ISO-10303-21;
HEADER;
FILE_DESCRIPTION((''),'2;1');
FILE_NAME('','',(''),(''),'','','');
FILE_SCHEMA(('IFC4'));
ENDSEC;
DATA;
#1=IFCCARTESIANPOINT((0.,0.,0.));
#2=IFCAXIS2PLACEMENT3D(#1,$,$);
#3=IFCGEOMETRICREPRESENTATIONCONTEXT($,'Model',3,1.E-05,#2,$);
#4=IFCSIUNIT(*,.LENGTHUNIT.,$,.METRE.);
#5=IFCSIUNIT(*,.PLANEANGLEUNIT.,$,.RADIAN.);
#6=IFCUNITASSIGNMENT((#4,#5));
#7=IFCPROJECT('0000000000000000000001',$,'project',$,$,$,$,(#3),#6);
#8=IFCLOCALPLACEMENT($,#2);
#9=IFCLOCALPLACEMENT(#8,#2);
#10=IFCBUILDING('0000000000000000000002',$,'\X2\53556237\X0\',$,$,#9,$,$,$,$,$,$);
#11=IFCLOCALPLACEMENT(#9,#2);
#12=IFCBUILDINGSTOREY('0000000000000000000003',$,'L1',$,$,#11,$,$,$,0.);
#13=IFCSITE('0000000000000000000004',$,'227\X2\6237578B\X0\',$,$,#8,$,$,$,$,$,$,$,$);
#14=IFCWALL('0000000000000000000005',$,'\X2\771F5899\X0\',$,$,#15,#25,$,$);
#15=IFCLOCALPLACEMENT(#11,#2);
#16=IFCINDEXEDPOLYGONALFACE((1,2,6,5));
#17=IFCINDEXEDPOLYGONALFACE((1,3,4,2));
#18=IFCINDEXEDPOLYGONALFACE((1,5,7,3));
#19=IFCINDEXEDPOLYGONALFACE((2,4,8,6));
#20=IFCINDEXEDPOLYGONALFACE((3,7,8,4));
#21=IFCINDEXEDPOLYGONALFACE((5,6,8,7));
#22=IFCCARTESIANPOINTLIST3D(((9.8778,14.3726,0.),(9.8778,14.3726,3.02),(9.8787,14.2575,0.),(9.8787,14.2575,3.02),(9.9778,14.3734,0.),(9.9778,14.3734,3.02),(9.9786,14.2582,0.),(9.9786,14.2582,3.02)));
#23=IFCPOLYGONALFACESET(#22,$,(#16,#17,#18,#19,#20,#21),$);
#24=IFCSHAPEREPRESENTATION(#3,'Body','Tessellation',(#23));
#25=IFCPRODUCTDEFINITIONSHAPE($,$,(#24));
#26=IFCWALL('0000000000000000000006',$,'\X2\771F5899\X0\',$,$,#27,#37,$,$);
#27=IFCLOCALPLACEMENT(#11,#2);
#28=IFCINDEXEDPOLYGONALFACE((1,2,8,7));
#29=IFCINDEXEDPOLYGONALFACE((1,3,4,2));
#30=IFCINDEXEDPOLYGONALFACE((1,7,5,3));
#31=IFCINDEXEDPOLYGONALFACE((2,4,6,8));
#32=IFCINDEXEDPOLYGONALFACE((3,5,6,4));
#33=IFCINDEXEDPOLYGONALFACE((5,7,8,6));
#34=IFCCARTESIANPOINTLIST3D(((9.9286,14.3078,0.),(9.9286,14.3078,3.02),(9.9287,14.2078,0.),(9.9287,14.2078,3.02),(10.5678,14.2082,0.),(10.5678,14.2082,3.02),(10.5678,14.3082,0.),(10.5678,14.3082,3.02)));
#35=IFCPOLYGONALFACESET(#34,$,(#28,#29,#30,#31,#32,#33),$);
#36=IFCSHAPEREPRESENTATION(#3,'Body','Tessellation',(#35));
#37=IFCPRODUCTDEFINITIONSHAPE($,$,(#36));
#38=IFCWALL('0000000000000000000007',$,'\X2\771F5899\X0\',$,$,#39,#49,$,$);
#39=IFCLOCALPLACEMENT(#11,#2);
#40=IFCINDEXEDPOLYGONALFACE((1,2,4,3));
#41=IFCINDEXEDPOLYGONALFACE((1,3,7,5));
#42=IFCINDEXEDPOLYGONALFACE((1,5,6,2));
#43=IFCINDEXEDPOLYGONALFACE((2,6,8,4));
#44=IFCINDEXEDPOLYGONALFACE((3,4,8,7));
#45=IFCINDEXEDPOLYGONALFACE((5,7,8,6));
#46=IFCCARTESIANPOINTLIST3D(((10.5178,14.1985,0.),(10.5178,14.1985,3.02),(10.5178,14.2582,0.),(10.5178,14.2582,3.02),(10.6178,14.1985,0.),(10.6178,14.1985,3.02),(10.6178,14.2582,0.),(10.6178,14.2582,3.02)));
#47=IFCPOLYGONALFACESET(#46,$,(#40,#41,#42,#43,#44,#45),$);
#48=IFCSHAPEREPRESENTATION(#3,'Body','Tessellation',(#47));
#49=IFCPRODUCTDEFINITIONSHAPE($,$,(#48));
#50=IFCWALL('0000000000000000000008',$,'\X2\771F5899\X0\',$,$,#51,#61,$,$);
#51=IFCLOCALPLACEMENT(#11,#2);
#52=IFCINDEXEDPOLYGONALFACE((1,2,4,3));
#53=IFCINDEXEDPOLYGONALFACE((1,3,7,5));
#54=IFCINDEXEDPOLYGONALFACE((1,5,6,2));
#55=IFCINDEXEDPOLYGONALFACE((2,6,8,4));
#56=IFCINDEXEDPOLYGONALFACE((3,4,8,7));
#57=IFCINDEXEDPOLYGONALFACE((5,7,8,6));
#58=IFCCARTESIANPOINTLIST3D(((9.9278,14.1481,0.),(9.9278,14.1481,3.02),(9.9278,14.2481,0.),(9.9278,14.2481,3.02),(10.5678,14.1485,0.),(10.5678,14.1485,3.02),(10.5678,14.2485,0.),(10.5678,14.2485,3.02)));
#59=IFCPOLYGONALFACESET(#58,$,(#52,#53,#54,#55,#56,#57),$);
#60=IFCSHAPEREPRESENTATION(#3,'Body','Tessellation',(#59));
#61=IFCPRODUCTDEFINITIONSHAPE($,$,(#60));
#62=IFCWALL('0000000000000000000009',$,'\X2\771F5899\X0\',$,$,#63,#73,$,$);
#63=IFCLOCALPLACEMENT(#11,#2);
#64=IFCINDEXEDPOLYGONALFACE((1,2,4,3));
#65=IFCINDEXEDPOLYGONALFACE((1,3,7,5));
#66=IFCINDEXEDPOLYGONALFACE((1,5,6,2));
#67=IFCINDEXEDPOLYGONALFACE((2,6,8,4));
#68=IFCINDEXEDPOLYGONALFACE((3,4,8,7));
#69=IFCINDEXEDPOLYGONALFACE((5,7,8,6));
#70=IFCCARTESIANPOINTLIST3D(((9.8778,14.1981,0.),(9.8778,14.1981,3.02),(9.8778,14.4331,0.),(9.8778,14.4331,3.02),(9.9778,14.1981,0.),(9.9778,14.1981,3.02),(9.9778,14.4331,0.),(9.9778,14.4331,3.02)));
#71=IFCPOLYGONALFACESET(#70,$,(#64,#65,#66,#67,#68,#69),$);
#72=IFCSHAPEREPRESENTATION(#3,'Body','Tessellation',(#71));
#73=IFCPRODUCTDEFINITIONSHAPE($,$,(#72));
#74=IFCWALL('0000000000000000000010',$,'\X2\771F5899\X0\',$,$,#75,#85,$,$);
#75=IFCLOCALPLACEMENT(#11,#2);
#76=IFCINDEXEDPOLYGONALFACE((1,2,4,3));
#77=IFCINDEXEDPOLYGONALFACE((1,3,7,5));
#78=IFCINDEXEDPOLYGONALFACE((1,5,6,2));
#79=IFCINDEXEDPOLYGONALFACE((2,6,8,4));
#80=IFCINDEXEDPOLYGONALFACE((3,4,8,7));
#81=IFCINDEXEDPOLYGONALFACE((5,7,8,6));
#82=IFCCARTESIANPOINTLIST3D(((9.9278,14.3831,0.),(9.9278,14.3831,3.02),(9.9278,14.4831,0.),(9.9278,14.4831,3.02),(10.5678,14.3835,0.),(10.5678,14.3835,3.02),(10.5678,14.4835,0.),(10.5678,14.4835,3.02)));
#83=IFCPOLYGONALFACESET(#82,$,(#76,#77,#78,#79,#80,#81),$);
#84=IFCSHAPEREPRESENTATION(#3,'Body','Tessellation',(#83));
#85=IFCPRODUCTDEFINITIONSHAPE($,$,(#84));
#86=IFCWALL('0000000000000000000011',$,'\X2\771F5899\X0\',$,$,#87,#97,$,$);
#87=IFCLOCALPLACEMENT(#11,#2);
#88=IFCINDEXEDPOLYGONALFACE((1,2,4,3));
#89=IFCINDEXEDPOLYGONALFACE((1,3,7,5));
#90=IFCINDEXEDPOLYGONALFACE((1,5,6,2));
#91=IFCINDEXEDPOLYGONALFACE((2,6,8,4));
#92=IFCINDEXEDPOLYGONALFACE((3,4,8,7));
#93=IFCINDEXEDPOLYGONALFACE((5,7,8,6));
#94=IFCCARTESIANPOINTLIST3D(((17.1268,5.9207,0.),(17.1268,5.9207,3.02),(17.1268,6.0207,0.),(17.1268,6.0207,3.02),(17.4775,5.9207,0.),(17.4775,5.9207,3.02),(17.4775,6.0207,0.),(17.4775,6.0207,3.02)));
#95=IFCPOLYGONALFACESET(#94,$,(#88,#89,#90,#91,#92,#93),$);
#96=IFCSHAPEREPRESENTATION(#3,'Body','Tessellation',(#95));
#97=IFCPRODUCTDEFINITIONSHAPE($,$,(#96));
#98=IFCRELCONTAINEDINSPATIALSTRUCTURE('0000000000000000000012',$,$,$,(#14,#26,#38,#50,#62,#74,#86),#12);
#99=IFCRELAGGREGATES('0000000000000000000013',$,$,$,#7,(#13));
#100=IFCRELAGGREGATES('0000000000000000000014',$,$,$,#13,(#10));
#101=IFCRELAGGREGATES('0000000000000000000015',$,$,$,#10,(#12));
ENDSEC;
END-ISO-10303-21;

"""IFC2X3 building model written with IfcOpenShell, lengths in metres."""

from ifc_helpers import new_model, si_unit, origin, place, context, project, spatial, polyline, outline, extrude, element, save


model = new_model("IFC2X3")

# Units and contexts
model_context = context("Model", 3, precision=1e-05, world=origin())
ifc_project = project(units=[si_unit("LENGTHUNIT", "METRE"), si_unit("PLANEANGLEUNIT", "RADIAN")], contexts=[model_context])

# Site, building, storey
site_placement = place(None, origin())
site = spatial("IfcSite", under=ifc_project, at=site_placement, Name="227户型")
building_placement = place(site_placement, origin())
building = spatial("IfcBuilding", under=site, at=building_placement, Name="单户")
storey_placement = place(building_placement, origin())
storey = spatial("IfcBuildingStorey", under=building, at=storey_placement, Name="L1", Elevation=0.0)

# Walls
wall_1_placement = place(storey_placement, origin())
element("IfcWall", 1, at=wall_1_placement, inside=storey, Name="真墙", context=model_context, shape_type="SweptSolid", body=[
    extrude(outline(polyline([(9.9778, 14.3734), (9.9786, 14.2582), (9.8787, 14.2575), (9.8778, 14.3726), (9.9778, 14.3734)])), origin(), (0.0, 0.0, 1.0), 3.02),
])
wall_2_placement = place(storey_placement, origin())
element("IfcWall", 2, at=wall_2_placement, inside=storey, Name="真墙", context=model_context, shape_type="SweptSolid", body=[
    extrude(outline(polyline([(9.9286, 14.3078), (10.5678, 14.3082), (10.5678, 14.2082), (9.9287, 14.2078), (9.9286, 14.3078)])), origin(), (0.0, 0.0, 1.0), 3.02),
])
wall_3_placement = place(storey_placement, origin())
element("IfcWall", 3, at=wall_3_placement, inside=storey, Name="真墙", context=model_context, shape_type="SweptSolid", body=[
    extrude(outline(polyline([(10.6178, 14.2582), (10.6178, 14.1985), (10.5178, 14.1985), (10.5178, 14.2582), (10.6178, 14.2582)])), origin(), (0.0, 0.0, 1.0), 3.02),
])
wall_4_placement = place(storey_placement, origin())
element("IfcWall", 4, at=wall_4_placement, inside=storey, Name="真墙", context=model_context, shape_type="SweptSolid", body=[
    extrude(outline(polyline([(10.5678, 14.1485), (9.9278, 14.1481), (9.9278, 14.2481), (10.5678, 14.2485), (10.5678, 14.1485)])), origin(), (0.0, 0.0, 1.0), 3.02),
])
wall_5_placement = place(storey_placement, origin())
element("IfcWall", 5, at=wall_5_placement, inside=storey, Name="真墙", context=model_context, shape_type="SweptSolid", body=[
    extrude(outline(polyline([(9.8778, 14.1981), (9.8778, 14.4331), (9.9778, 14.4331), (9.9778, 14.1981), (9.8778, 14.1981)])), origin(), (0.0, 0.0, 1.0), 3.02),
])
wall_6_placement = place(storey_placement, origin())
element("IfcWall", 6, at=wall_6_placement, inside=storey, Name="真墙", context=model_context, shape_type="SweptSolid", body=[
    extrude(outline(polyline([(9.9278, 14.4831), (10.5678, 14.4835), (10.5678, 14.3835), (9.9278, 14.3831), (9.9278, 14.4831)])), origin(), (0.0, 0.0, 1.0), 3.02),
])
wall_7_placement = place(storey_placement, origin())
element("IfcWall", 7, at=wall_7_placement, inside=storey, Name="真墙", context=model_context, shape_type="SweptSolid", body=[
    extrude(outline(polyline([(17.1268, 6.0207), (17.4775, 6.0207), (17.4775, 5.9207), (17.1268, 5.9207), (17.1268, 6.0207)])), origin(), (0.0, 0.0, 1.0), 3.02),
])

save(model, "model.ifc")
